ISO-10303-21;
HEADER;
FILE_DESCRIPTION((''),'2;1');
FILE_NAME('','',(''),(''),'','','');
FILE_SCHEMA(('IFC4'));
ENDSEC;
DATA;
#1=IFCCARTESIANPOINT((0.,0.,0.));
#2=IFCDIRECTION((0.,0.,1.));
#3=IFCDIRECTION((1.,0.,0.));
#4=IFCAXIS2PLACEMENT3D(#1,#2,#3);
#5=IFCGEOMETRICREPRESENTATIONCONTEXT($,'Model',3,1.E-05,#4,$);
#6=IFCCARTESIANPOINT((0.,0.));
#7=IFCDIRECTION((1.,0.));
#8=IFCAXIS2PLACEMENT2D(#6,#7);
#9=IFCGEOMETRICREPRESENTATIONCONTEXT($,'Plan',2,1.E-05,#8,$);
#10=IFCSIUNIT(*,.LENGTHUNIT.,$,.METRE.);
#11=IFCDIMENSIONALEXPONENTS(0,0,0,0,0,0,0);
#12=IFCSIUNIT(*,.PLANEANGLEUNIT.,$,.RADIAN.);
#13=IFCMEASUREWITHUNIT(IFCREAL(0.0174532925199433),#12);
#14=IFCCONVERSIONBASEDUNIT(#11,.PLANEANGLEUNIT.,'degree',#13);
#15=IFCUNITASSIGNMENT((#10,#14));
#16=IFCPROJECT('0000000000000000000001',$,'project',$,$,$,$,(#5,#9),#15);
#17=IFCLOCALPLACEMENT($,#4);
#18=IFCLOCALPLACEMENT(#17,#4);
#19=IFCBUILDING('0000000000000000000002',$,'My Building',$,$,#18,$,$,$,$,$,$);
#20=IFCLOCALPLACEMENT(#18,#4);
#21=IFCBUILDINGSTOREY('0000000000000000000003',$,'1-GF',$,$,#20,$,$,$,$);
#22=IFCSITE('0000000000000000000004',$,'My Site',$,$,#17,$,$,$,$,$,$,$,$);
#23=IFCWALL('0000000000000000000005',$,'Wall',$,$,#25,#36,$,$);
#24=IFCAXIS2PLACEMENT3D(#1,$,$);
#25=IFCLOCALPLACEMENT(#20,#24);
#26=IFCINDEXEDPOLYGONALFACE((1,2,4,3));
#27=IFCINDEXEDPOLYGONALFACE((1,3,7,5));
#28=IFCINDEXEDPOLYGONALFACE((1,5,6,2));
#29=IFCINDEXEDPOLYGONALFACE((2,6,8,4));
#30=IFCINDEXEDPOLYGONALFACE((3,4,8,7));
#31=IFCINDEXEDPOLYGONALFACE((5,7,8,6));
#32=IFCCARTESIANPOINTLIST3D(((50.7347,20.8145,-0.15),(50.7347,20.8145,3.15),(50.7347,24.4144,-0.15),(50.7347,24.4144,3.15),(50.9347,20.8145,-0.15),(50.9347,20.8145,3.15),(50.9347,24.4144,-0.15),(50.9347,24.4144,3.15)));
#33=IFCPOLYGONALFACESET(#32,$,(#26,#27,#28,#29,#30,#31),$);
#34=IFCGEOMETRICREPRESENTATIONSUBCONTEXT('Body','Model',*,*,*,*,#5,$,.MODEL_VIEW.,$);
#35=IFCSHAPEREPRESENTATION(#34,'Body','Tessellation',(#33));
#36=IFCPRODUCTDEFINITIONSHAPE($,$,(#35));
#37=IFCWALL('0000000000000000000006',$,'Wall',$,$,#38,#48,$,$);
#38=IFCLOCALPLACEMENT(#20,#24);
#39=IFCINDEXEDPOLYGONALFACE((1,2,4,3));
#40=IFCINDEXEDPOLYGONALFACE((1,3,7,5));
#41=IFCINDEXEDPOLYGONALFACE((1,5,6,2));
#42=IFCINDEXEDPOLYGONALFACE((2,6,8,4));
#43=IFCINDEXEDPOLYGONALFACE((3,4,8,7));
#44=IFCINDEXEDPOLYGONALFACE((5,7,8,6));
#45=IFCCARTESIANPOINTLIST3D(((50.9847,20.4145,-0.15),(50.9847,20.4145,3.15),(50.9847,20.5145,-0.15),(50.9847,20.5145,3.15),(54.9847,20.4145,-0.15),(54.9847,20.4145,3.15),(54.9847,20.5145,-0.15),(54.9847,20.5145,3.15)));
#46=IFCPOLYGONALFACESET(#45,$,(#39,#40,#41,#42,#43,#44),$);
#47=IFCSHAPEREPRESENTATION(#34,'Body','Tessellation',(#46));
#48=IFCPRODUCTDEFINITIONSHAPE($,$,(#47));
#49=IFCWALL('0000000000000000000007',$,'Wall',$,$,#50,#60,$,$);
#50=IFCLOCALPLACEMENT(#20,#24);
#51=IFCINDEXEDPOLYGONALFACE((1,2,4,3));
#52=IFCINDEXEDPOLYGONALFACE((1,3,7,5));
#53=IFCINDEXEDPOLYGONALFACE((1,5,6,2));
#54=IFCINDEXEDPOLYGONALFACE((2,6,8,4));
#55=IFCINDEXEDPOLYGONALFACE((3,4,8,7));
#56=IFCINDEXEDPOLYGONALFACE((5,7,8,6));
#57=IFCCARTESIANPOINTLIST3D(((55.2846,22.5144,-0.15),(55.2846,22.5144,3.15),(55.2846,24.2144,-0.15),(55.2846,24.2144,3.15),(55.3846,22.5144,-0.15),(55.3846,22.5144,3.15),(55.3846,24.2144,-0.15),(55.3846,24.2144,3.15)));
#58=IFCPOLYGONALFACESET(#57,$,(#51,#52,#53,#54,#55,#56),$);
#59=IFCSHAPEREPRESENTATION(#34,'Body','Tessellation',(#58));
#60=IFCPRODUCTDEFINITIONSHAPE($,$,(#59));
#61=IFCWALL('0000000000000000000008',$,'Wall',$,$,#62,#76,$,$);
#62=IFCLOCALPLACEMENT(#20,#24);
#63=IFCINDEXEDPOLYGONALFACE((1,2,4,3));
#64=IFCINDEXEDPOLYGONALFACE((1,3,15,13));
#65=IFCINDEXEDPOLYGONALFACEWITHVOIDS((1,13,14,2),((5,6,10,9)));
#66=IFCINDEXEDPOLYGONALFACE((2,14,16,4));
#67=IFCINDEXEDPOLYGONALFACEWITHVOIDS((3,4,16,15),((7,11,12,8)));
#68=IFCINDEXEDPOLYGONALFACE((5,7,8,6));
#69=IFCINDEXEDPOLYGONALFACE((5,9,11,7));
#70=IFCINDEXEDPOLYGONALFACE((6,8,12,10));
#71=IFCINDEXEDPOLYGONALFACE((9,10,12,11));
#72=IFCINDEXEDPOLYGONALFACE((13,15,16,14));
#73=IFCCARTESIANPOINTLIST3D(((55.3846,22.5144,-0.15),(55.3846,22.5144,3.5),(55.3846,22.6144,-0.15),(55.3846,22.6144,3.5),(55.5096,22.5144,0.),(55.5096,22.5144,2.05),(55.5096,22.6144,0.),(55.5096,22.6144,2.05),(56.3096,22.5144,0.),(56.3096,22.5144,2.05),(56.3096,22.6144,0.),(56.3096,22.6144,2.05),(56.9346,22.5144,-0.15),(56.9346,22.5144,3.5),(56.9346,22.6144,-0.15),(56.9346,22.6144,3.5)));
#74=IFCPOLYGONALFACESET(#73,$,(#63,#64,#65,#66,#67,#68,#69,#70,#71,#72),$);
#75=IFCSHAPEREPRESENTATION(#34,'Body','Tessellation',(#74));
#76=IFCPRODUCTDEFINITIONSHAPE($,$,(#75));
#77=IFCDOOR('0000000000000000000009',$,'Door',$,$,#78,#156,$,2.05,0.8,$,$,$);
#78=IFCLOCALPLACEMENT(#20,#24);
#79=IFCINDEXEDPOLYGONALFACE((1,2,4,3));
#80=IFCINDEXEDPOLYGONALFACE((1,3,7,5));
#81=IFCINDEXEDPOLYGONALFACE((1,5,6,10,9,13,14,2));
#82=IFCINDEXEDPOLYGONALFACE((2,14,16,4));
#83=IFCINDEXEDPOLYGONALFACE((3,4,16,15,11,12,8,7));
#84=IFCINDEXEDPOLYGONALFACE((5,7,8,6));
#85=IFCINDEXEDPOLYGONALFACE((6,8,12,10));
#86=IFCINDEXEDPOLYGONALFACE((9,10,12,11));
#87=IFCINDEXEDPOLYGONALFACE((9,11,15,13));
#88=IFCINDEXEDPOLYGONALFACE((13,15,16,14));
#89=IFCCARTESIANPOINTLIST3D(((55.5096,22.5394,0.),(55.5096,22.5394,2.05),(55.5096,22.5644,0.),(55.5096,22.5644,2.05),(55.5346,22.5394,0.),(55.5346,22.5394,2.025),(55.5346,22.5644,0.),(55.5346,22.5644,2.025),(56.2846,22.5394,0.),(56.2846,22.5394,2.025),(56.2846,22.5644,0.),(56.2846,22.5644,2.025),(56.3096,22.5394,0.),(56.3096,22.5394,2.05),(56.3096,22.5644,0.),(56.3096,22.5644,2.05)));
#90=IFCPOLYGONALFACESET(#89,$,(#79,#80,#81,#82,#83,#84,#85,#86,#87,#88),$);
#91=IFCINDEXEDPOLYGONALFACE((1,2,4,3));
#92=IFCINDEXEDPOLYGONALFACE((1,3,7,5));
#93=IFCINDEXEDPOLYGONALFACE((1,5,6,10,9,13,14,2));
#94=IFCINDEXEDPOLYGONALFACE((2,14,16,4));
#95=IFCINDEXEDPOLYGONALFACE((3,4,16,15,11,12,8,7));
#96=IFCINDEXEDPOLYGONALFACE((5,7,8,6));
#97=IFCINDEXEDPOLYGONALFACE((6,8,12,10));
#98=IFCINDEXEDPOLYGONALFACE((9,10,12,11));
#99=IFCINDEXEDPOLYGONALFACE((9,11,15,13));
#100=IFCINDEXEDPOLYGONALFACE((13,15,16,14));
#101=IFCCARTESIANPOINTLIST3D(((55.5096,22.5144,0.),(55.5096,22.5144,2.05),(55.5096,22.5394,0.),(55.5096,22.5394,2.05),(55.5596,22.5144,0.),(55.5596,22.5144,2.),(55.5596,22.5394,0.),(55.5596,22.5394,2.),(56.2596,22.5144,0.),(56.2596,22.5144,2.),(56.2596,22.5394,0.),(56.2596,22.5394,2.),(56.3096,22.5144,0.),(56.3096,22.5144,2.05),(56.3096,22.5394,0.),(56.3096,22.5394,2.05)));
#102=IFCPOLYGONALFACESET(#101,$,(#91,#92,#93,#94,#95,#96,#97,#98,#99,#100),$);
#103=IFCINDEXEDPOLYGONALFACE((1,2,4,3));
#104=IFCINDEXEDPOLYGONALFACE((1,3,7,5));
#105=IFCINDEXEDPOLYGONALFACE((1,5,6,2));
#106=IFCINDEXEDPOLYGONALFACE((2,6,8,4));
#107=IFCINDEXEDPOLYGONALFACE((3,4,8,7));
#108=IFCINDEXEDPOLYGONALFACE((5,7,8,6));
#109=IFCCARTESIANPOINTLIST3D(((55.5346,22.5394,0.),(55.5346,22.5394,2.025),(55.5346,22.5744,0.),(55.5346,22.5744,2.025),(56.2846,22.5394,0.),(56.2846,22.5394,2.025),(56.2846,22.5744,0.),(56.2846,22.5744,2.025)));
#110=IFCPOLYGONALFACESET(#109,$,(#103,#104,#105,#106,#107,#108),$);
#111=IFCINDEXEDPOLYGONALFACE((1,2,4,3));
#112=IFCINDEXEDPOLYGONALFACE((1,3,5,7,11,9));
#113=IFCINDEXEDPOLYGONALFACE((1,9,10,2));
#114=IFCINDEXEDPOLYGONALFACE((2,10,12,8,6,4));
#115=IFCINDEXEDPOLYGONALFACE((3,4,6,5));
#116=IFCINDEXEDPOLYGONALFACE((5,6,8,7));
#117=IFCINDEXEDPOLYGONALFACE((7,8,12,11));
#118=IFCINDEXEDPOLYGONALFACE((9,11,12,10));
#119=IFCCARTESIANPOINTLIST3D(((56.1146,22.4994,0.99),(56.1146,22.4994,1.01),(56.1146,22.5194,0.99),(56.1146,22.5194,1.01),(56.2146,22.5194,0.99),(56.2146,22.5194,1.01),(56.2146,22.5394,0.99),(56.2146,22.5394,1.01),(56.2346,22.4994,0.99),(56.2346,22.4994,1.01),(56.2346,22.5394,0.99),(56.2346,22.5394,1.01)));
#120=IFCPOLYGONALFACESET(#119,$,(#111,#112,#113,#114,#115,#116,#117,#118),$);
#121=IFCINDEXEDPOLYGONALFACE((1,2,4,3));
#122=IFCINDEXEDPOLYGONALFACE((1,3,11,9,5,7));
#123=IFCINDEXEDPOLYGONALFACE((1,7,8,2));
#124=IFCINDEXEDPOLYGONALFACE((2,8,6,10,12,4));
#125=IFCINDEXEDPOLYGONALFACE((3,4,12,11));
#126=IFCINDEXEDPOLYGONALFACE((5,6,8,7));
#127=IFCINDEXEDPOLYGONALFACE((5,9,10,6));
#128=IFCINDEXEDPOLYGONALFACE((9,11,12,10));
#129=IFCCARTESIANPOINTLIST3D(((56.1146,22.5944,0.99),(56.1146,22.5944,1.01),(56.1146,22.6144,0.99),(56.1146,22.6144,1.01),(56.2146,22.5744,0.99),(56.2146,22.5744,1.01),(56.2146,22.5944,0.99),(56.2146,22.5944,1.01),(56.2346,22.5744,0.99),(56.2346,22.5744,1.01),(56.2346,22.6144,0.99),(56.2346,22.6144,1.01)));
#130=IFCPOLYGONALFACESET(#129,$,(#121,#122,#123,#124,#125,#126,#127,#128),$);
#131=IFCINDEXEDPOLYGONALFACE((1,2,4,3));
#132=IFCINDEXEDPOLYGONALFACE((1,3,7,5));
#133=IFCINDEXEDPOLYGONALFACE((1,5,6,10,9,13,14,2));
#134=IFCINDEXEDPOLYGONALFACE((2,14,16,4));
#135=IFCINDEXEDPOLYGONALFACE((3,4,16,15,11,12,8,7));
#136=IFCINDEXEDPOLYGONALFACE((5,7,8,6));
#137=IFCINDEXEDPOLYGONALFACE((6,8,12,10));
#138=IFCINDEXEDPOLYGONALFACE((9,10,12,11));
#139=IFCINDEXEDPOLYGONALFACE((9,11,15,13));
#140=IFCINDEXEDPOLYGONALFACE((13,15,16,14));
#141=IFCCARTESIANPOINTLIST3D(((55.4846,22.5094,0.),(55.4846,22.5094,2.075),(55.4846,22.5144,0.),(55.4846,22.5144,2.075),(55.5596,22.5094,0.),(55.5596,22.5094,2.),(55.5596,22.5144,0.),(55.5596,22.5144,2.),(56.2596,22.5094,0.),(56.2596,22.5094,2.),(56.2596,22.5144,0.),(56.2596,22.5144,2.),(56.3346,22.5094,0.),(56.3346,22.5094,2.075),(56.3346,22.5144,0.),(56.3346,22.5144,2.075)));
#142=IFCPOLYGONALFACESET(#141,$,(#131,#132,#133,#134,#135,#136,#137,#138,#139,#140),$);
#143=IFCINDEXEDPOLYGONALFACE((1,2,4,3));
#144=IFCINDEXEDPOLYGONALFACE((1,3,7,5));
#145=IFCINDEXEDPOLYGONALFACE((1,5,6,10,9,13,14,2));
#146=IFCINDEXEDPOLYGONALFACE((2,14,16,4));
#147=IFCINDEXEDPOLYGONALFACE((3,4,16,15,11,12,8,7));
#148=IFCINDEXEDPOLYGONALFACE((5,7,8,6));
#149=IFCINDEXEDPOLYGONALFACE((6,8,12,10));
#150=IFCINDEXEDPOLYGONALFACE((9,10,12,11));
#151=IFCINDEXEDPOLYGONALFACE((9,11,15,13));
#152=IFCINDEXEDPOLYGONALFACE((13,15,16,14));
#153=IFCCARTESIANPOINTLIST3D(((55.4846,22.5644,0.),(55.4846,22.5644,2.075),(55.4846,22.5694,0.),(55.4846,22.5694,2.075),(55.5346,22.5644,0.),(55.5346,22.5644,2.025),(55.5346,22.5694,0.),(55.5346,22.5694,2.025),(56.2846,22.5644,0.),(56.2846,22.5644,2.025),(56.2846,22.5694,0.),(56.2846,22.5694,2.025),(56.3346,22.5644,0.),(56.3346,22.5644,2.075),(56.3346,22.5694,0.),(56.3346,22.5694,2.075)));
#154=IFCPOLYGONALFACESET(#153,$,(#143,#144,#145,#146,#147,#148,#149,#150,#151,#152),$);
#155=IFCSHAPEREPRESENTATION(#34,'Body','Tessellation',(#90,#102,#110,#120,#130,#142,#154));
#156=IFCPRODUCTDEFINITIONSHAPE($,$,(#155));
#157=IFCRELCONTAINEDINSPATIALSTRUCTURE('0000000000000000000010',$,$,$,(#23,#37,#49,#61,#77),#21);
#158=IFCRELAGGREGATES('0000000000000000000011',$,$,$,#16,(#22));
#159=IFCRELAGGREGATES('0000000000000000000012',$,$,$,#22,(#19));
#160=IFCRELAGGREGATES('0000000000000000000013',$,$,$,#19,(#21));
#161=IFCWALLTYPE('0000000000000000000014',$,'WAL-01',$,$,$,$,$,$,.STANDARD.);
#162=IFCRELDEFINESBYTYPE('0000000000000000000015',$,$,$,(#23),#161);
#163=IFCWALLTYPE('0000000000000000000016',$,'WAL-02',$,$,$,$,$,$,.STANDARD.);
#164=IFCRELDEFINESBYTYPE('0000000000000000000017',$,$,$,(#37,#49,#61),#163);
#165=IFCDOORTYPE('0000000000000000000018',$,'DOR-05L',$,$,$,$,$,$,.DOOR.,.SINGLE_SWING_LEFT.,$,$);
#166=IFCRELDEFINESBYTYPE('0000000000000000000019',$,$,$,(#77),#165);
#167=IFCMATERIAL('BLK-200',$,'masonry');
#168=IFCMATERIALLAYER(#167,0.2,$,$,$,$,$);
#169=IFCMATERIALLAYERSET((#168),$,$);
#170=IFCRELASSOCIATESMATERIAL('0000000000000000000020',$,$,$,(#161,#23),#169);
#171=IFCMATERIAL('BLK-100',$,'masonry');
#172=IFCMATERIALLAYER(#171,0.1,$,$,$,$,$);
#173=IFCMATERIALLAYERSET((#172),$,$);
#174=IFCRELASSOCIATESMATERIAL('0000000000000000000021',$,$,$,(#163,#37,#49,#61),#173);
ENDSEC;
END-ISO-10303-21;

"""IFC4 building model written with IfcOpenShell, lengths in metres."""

from ifc_helpers import new_model, entity, si_unit, converted_unit, frame, origin_with_axes, origin_2d_with_axis, place, context, subcontext, project, spatial, line, indexed_curve, outline, extrude, shape, source, transform, mapped, material, layer, layer_set, layer_usage, type_object, type_shapes, element, fill, save


model = new_model("IFC4")

# Units and contexts
model_context = context("Model", 3, precision=1e-05, world=origin_with_axes())
plan_context = context("Plan", 2, precision=1e-05, world=origin_2d_with_axis())
body_context_1 = subcontext(model_context, "Body", "Model", "MODEL_VIEW")
body_context_2 = subcontext(plan_context, "Body", "Plan", "PLAN_VIEW")
ifc_project = project(units=[si_unit("LENGTHUNIT", "METRE"), converted_unit("PLANEANGLEUNIT", "degree", entity("IfcReal", 0.0174532925199433), si_unit("PLANEANGLEUNIT", "RADIAN"), dimensions=[0, 0, 0, 0, 0, 0, 0])], contexts=[model_context, plan_context])

# Site, building, storey
site_placement = place(None, origin_with_axes())
site = spatial("IfcSite", under=ifc_project, at=site_placement, Name="My Site")
building_placement = place(site_placement, origin_with_axes())
building = spatial("IfcBuilding", under=site, at=building_placement, Name="My Building")
storey_placement = place(building_placement, origin_with_axes())
storey = spatial("IfcBuildingStorey", under=building, at=storey_placement, Name="1-GF")

# Shared definitions
ifc_material_1 = material(Name="BLK-200", Category="masonry")
ifc_layer_1 = layer(ifc_material_1, 0.2)
ifc_layer_set_1 = layer_set([ifc_layer_1])
wall_type_1 = type_object("IfcWallType", Name="WAL-01", PredefinedType="STANDARD", material=ifc_layer_set_1)

# Walls
ifc_layer_usage_1 = layer_usage(ifc_layer_set_1, "AXIS2", "POSITIVE", 0.0)
wall_1_placement = place(storey_placement, frame((50.7347, 24.4144, -0.15), z_axis=(0.0, 0.0, 1.0), x_axis=(-0.000001, -1.0, 0.0)))
element("IfcWall", 1, at=wall_1_placement, inside=storey, type_object=wall_type_1, material=ifc_layer_usage_1, Name="Wall", context=body_context_1, shape_type="SweptSolid", body=[
    extrude(outline(indexed_curve([(0.0, 0.0), (0.0, 0.2), (3.5999, 0.2), (3.5999, 0.0), (0.0, 0.0)], self_intersect=False)), origin_with_axes(), (0.0, 0.0, 1.0), 3.3),
])
ifc_material_2 = material(Name="BLK-100", Category="masonry")
ifc_layer_2 = layer(ifc_material_2, 0.1)
ifc_layer_set_2 = layer_set([ifc_layer_2])
ifc_layer_usage_2 = layer_usage(ifc_layer_set_2, "AXIS2", "POSITIVE", 0.0)
wall_type_2 = type_object("IfcWallType", Name="WAL-02", PredefinedType="STANDARD", material=ifc_layer_set_2)
wall_2_placement = place(storey_placement, frame((50.9847, 20.4145, -0.15), z_axis=(0.0, 0.0, 1.0), x_axis=(1.0, -0.000001, 0.0)))
element("IfcWall", 2, at=wall_2_placement, inside=storey, type_object=wall_type_2, material=ifc_layer_usage_2, Name="Wall", context=body_context_1, shape_type="SweptSolid", body=[
    extrude(outline(indexed_curve([(0.0, 0.0), (0.0, 0.1), (4.0, 0.1), (4.0, 0.0), (0.0, 0.0)], self_intersect=False)), origin_with_axes(), (0.0, 0.0, 1.0), 3.3),
])
ifc_layer_usage_3 = layer_usage(ifc_layer_set_2, "AXIS2", "POSITIVE", 0.0)
wall_3_placement = place(storey_placement, frame((55.3846, 22.5144, -0.15), z_axis=(0.0, 0.0, 1.0), x_axis=(0.0, 1.0, 0.0)))
element("IfcWall", 3, at=wall_3_placement, inside=storey, type_object=wall_type_2, material=ifc_layer_usage_3, Name="Wall", context=body_context_1, shape_type="SweptSolid", body=[
    extrude(outline(indexed_curve([(0.0, 0.0), (0.0, 0.1), (1.7, 0.1), (1.7, 0.0), (0.0, 0.0)], self_intersect=False)), origin_with_axes(), (0.0, 0.0, 1.0), 3.3),
])

# Wall, opening, door
ifc_layer_usage_4 = layer_usage(ifc_layer_set_2, "AXIS2", "POSITIVE", 0.0)
wall_4_placement = place(storey_placement, frame((55.3846, 22.5144, -0.15), z_axis=(0.0, 0.0, 1.0), x_axis=(1.0, 0.0, 0.0)))
wall_4 = element("IfcWall", 4, at=wall_4_placement, inside=storey, type_object=wall_type_2, material=ifc_layer_usage_4, Name="Wall", context=body_context_1, shape_type="SweptSolid", body=[
    extrude(outline(indexed_curve([(0.0, 0.0), (0.0, 0.1), (1.55, 0.1), (1.55, 0.0), (0.0, 0.0)], self_intersect=False)), origin_with_axes(), (0.0, 0.0, 1.0), 3.65),
])
shared_shape_1 = source(origin_with_axes(), body_context_1, "Body", "SweptSolid", [
    extrude(outline(indexed_curve([(0.0, 0.0), (0.8, 0.0), (0.8, 2.05), (0.0, 2.05)], segments=[line(1, 2, 3, 4, 1)])), frame((0.0, -0.1, 0.0), z_axis=(0.0, -1.0, 0.0), x_axis=(1.0, 0.0, 0.0)), (0.0, 0.0, -1.0), 0.3),
])
opening_1_placement = place(wall_4_placement, frame((0.125, 0.0, 0.15), z_axis=(0.0, 0.0, 1.0), x_axis=(1.0, 0.0, 0.0)))
opening_1 = element("IfcOpeningElement", 5, at=opening_1_placement, cuts=wall_4, PredefinedType="OPENING", context=body_context_1, shape_type="MappedRepresentation", body=[
    mapped(shared_shape_1, transform((0.0, 0.0, 0.0), x_axis=(1.0, 0.0, 0.0), y_axis=(0.0, 1.0, 0.0), z_axis=(0.0, 0.0, 1.0), scale=1.0)),
])
door_type_1 = type_object("IfcDoorType", Name="DOR-05L", OperationType="SINGLE_SWING_LEFT", PredefinedType="DOOR")
shared_shape_2 = source(origin_with_axes(), body_context_1, "Body", "SweptSolid", [
    extrude(outline(indexed_curve([(0.0, 0.0), (0.0, 2.05), (0.8, 2.05), (0.8, 0.0), (0.775, 0.0), (0.775, 2.025), (0.025, 2.025), (0.025, 0.0)], segments=[line(1, 2, 3, 4, 5, 6, 7, 8, 1)])), frame((0.0, 0.025, 0.0), z_axis=(0.0, -1.0, 0.0), x_axis=(1.0, 0.0, 0.0)), (0.0, 0.0, -1.0), 0.025),
    extrude(outline(indexed_curve([(0.0, 0.0), (0.0, 2.05), (0.8, 2.05), (0.8, 0.0), (0.75, 0.0), (0.75, 2.0), (0.05, 2.0), (0.05, 0.0)], segments=[line(1, 2, 3, 4, 5, 6, 7, 8, 1)])), frame((0.0, 0.0, 0.0), z_axis=(0.0, -1.0, 0.0), x_axis=(1.0, 0.0, 0.0)), (0.0, 0.0, -1.0), 0.025),
    extrude(outline(indexed_curve([(0.0, 0.0), (0.75, 0.0), (0.75, 0.035), (0.0, 0.035)], segments=[line(1, 2, 3, 4, 1)])), frame((0.025, 0.025, 0.0), z_axis=(0.0, 0.0, 1.0), x_axis=(1.0, 0.0, 0.0)), (0.0, 0.0, 1.0), 2.025),
    extrude(outline(indexed_curve([(0.0, 0.0), (0.0, -0.04), (-0.12, -0.04), (-0.12, -0.02), (-0.02, -0.02), (-0.02, 0.0)], segments=[line(1, 2, 3, 4, 5, 6, 1)])), frame((0.725, 0.025, 0.99), z_axis=(0.0, 0.0, 1.0), x_axis=(1.0, 0.0, 0.0)), (0.0, 0.0, 1.0), 0.02),
    extrude(outline(indexed_curve([(0.0, 0.0), (0.0, 0.04), (-0.12, 0.04), (-0.12, 0.02), (-0.02, 0.02), (-0.02, 0.0)], segments=[line(1, 2, 3, 4, 5, 6, 1)])), frame((0.725, 0.06, 0.99), z_axis=(0.0, 0.0, 1.0), x_axis=(1.0, 0.0, 0.0)), (0.0, 0.0, 1.0), 0.02),
    extrude(outline(indexed_curve([(0.0, 0.0), (0.0, 2.075), (0.85, 2.075), (0.85, 0.0), (0.775, 0.0), (0.775, 2.0), (0.075, 2.0), (0.075, 0.0)], segments=[line(1, 2, 3, 4, 5, 6, 7, 8, 1)])), frame((-0.025, -0.005, 0.0), z_axis=(0.0, -1.0, 0.0), x_axis=(1.0, 0.0, 0.0)), (0.0, 0.0, -1.0), 0.005),
    extrude(outline(indexed_curve([(0.0, 0.0), (0.0, 2.075), (0.85, 2.075), (0.85, 0.0), (0.8, 0.0), (0.8, 2.025), (0.05, 2.025), (0.05, 0.0)], segments=[line(1, 2, 3, 4, 5, 6, 7, 8, 1)])), frame((-0.025, 0.05, 0.0), z_axis=(0.0, -1.0, 0.0), x_axis=(1.0, 0.0, 0.0)), (0.0, 0.0, -1.0), 0.005),
])
shared_shape_3 = source(origin_with_axes(), body_context_2, "Body", "Curve2D", [
    entity("IfcIndexedPolyCurve", entity("IfcCartesianPointList2D", [[0.0, 0.0], [0.0, 0.05], [0.025, 0.05], [0.025, 0.025], [0.05, 0.025], [0.05, 0.0]]), [entity("IfcLineIndex", [1, 2, 3, 4, 5, 6, 1])]),
    entity("IfcIndexedPolyCurve", entity("IfcCartesianPointList2D", [[0.8, 0.0], [0.8, 0.05], [0.775, 0.05], [0.775, 0.025], [0.75, 0.025], [0.75, 0.0]]), [entity("IfcLineIndex", [1, 2, 3, 4, 5, 6, 1])]),
    entity("IfcTrimmedCurve", entity("IfcEllipse", entity("IfcAxis2Placement2D", entity("IfcCartesianPoint", [0.06, 0.05]), entity("IfcDirection", [1.0, 0.0])), 0.715, 0.75), [entity("IfcCartesianPoint", [0.775, 0.05])], [entity("IfcCartesianPoint", [0.06, 0.8])], True, "CARTESIAN"),
    entity("IfcIndexedPolyCurve", entity("IfcCartesianPointList2D", [[0.025, 0.05], [0.06, 0.05], [0.06, 0.8], [0.025, 0.8]]), [entity("IfcLineIndex", [1, 2, 3, 4, 1])]),
])
type_shapes(door_type_1, [shared_shape_2, shared_shape_3])
door_1_placement = place(opening_1_placement, origin_with_axes())
door_1 = element("IfcDoor", 6, at=door_1_placement, inside=storey, type_object=door_type_1, Name="Door", OverallHeight=2.05, OverallWidth=0.8, shapes=[
    shape(body_context_1, "Body", "MappedRepresentation", [mapped(shared_shape_2, transform((0.0, 0.0, 0.0), x_axis=(1.0, 0.0, 0.0), y_axis=(0.0, 1.0, 0.0), z_axis=(0.0, 0.0, 1.0), scale=1.0))]),
    shape(body_context_2, "Body", "MappedRepresentation", [mapped(shared_shape_3, transform((0.0, 0.0, 0.0), x_axis=(1.0, 0.0, 0.0), y_axis=(0.0, 1.0, 0.0), z_axis=(0.0, 0.0, 1.0), scale=1.0))]),
])
fill(opening_1, door_1)

save(model, "model.ifc")
